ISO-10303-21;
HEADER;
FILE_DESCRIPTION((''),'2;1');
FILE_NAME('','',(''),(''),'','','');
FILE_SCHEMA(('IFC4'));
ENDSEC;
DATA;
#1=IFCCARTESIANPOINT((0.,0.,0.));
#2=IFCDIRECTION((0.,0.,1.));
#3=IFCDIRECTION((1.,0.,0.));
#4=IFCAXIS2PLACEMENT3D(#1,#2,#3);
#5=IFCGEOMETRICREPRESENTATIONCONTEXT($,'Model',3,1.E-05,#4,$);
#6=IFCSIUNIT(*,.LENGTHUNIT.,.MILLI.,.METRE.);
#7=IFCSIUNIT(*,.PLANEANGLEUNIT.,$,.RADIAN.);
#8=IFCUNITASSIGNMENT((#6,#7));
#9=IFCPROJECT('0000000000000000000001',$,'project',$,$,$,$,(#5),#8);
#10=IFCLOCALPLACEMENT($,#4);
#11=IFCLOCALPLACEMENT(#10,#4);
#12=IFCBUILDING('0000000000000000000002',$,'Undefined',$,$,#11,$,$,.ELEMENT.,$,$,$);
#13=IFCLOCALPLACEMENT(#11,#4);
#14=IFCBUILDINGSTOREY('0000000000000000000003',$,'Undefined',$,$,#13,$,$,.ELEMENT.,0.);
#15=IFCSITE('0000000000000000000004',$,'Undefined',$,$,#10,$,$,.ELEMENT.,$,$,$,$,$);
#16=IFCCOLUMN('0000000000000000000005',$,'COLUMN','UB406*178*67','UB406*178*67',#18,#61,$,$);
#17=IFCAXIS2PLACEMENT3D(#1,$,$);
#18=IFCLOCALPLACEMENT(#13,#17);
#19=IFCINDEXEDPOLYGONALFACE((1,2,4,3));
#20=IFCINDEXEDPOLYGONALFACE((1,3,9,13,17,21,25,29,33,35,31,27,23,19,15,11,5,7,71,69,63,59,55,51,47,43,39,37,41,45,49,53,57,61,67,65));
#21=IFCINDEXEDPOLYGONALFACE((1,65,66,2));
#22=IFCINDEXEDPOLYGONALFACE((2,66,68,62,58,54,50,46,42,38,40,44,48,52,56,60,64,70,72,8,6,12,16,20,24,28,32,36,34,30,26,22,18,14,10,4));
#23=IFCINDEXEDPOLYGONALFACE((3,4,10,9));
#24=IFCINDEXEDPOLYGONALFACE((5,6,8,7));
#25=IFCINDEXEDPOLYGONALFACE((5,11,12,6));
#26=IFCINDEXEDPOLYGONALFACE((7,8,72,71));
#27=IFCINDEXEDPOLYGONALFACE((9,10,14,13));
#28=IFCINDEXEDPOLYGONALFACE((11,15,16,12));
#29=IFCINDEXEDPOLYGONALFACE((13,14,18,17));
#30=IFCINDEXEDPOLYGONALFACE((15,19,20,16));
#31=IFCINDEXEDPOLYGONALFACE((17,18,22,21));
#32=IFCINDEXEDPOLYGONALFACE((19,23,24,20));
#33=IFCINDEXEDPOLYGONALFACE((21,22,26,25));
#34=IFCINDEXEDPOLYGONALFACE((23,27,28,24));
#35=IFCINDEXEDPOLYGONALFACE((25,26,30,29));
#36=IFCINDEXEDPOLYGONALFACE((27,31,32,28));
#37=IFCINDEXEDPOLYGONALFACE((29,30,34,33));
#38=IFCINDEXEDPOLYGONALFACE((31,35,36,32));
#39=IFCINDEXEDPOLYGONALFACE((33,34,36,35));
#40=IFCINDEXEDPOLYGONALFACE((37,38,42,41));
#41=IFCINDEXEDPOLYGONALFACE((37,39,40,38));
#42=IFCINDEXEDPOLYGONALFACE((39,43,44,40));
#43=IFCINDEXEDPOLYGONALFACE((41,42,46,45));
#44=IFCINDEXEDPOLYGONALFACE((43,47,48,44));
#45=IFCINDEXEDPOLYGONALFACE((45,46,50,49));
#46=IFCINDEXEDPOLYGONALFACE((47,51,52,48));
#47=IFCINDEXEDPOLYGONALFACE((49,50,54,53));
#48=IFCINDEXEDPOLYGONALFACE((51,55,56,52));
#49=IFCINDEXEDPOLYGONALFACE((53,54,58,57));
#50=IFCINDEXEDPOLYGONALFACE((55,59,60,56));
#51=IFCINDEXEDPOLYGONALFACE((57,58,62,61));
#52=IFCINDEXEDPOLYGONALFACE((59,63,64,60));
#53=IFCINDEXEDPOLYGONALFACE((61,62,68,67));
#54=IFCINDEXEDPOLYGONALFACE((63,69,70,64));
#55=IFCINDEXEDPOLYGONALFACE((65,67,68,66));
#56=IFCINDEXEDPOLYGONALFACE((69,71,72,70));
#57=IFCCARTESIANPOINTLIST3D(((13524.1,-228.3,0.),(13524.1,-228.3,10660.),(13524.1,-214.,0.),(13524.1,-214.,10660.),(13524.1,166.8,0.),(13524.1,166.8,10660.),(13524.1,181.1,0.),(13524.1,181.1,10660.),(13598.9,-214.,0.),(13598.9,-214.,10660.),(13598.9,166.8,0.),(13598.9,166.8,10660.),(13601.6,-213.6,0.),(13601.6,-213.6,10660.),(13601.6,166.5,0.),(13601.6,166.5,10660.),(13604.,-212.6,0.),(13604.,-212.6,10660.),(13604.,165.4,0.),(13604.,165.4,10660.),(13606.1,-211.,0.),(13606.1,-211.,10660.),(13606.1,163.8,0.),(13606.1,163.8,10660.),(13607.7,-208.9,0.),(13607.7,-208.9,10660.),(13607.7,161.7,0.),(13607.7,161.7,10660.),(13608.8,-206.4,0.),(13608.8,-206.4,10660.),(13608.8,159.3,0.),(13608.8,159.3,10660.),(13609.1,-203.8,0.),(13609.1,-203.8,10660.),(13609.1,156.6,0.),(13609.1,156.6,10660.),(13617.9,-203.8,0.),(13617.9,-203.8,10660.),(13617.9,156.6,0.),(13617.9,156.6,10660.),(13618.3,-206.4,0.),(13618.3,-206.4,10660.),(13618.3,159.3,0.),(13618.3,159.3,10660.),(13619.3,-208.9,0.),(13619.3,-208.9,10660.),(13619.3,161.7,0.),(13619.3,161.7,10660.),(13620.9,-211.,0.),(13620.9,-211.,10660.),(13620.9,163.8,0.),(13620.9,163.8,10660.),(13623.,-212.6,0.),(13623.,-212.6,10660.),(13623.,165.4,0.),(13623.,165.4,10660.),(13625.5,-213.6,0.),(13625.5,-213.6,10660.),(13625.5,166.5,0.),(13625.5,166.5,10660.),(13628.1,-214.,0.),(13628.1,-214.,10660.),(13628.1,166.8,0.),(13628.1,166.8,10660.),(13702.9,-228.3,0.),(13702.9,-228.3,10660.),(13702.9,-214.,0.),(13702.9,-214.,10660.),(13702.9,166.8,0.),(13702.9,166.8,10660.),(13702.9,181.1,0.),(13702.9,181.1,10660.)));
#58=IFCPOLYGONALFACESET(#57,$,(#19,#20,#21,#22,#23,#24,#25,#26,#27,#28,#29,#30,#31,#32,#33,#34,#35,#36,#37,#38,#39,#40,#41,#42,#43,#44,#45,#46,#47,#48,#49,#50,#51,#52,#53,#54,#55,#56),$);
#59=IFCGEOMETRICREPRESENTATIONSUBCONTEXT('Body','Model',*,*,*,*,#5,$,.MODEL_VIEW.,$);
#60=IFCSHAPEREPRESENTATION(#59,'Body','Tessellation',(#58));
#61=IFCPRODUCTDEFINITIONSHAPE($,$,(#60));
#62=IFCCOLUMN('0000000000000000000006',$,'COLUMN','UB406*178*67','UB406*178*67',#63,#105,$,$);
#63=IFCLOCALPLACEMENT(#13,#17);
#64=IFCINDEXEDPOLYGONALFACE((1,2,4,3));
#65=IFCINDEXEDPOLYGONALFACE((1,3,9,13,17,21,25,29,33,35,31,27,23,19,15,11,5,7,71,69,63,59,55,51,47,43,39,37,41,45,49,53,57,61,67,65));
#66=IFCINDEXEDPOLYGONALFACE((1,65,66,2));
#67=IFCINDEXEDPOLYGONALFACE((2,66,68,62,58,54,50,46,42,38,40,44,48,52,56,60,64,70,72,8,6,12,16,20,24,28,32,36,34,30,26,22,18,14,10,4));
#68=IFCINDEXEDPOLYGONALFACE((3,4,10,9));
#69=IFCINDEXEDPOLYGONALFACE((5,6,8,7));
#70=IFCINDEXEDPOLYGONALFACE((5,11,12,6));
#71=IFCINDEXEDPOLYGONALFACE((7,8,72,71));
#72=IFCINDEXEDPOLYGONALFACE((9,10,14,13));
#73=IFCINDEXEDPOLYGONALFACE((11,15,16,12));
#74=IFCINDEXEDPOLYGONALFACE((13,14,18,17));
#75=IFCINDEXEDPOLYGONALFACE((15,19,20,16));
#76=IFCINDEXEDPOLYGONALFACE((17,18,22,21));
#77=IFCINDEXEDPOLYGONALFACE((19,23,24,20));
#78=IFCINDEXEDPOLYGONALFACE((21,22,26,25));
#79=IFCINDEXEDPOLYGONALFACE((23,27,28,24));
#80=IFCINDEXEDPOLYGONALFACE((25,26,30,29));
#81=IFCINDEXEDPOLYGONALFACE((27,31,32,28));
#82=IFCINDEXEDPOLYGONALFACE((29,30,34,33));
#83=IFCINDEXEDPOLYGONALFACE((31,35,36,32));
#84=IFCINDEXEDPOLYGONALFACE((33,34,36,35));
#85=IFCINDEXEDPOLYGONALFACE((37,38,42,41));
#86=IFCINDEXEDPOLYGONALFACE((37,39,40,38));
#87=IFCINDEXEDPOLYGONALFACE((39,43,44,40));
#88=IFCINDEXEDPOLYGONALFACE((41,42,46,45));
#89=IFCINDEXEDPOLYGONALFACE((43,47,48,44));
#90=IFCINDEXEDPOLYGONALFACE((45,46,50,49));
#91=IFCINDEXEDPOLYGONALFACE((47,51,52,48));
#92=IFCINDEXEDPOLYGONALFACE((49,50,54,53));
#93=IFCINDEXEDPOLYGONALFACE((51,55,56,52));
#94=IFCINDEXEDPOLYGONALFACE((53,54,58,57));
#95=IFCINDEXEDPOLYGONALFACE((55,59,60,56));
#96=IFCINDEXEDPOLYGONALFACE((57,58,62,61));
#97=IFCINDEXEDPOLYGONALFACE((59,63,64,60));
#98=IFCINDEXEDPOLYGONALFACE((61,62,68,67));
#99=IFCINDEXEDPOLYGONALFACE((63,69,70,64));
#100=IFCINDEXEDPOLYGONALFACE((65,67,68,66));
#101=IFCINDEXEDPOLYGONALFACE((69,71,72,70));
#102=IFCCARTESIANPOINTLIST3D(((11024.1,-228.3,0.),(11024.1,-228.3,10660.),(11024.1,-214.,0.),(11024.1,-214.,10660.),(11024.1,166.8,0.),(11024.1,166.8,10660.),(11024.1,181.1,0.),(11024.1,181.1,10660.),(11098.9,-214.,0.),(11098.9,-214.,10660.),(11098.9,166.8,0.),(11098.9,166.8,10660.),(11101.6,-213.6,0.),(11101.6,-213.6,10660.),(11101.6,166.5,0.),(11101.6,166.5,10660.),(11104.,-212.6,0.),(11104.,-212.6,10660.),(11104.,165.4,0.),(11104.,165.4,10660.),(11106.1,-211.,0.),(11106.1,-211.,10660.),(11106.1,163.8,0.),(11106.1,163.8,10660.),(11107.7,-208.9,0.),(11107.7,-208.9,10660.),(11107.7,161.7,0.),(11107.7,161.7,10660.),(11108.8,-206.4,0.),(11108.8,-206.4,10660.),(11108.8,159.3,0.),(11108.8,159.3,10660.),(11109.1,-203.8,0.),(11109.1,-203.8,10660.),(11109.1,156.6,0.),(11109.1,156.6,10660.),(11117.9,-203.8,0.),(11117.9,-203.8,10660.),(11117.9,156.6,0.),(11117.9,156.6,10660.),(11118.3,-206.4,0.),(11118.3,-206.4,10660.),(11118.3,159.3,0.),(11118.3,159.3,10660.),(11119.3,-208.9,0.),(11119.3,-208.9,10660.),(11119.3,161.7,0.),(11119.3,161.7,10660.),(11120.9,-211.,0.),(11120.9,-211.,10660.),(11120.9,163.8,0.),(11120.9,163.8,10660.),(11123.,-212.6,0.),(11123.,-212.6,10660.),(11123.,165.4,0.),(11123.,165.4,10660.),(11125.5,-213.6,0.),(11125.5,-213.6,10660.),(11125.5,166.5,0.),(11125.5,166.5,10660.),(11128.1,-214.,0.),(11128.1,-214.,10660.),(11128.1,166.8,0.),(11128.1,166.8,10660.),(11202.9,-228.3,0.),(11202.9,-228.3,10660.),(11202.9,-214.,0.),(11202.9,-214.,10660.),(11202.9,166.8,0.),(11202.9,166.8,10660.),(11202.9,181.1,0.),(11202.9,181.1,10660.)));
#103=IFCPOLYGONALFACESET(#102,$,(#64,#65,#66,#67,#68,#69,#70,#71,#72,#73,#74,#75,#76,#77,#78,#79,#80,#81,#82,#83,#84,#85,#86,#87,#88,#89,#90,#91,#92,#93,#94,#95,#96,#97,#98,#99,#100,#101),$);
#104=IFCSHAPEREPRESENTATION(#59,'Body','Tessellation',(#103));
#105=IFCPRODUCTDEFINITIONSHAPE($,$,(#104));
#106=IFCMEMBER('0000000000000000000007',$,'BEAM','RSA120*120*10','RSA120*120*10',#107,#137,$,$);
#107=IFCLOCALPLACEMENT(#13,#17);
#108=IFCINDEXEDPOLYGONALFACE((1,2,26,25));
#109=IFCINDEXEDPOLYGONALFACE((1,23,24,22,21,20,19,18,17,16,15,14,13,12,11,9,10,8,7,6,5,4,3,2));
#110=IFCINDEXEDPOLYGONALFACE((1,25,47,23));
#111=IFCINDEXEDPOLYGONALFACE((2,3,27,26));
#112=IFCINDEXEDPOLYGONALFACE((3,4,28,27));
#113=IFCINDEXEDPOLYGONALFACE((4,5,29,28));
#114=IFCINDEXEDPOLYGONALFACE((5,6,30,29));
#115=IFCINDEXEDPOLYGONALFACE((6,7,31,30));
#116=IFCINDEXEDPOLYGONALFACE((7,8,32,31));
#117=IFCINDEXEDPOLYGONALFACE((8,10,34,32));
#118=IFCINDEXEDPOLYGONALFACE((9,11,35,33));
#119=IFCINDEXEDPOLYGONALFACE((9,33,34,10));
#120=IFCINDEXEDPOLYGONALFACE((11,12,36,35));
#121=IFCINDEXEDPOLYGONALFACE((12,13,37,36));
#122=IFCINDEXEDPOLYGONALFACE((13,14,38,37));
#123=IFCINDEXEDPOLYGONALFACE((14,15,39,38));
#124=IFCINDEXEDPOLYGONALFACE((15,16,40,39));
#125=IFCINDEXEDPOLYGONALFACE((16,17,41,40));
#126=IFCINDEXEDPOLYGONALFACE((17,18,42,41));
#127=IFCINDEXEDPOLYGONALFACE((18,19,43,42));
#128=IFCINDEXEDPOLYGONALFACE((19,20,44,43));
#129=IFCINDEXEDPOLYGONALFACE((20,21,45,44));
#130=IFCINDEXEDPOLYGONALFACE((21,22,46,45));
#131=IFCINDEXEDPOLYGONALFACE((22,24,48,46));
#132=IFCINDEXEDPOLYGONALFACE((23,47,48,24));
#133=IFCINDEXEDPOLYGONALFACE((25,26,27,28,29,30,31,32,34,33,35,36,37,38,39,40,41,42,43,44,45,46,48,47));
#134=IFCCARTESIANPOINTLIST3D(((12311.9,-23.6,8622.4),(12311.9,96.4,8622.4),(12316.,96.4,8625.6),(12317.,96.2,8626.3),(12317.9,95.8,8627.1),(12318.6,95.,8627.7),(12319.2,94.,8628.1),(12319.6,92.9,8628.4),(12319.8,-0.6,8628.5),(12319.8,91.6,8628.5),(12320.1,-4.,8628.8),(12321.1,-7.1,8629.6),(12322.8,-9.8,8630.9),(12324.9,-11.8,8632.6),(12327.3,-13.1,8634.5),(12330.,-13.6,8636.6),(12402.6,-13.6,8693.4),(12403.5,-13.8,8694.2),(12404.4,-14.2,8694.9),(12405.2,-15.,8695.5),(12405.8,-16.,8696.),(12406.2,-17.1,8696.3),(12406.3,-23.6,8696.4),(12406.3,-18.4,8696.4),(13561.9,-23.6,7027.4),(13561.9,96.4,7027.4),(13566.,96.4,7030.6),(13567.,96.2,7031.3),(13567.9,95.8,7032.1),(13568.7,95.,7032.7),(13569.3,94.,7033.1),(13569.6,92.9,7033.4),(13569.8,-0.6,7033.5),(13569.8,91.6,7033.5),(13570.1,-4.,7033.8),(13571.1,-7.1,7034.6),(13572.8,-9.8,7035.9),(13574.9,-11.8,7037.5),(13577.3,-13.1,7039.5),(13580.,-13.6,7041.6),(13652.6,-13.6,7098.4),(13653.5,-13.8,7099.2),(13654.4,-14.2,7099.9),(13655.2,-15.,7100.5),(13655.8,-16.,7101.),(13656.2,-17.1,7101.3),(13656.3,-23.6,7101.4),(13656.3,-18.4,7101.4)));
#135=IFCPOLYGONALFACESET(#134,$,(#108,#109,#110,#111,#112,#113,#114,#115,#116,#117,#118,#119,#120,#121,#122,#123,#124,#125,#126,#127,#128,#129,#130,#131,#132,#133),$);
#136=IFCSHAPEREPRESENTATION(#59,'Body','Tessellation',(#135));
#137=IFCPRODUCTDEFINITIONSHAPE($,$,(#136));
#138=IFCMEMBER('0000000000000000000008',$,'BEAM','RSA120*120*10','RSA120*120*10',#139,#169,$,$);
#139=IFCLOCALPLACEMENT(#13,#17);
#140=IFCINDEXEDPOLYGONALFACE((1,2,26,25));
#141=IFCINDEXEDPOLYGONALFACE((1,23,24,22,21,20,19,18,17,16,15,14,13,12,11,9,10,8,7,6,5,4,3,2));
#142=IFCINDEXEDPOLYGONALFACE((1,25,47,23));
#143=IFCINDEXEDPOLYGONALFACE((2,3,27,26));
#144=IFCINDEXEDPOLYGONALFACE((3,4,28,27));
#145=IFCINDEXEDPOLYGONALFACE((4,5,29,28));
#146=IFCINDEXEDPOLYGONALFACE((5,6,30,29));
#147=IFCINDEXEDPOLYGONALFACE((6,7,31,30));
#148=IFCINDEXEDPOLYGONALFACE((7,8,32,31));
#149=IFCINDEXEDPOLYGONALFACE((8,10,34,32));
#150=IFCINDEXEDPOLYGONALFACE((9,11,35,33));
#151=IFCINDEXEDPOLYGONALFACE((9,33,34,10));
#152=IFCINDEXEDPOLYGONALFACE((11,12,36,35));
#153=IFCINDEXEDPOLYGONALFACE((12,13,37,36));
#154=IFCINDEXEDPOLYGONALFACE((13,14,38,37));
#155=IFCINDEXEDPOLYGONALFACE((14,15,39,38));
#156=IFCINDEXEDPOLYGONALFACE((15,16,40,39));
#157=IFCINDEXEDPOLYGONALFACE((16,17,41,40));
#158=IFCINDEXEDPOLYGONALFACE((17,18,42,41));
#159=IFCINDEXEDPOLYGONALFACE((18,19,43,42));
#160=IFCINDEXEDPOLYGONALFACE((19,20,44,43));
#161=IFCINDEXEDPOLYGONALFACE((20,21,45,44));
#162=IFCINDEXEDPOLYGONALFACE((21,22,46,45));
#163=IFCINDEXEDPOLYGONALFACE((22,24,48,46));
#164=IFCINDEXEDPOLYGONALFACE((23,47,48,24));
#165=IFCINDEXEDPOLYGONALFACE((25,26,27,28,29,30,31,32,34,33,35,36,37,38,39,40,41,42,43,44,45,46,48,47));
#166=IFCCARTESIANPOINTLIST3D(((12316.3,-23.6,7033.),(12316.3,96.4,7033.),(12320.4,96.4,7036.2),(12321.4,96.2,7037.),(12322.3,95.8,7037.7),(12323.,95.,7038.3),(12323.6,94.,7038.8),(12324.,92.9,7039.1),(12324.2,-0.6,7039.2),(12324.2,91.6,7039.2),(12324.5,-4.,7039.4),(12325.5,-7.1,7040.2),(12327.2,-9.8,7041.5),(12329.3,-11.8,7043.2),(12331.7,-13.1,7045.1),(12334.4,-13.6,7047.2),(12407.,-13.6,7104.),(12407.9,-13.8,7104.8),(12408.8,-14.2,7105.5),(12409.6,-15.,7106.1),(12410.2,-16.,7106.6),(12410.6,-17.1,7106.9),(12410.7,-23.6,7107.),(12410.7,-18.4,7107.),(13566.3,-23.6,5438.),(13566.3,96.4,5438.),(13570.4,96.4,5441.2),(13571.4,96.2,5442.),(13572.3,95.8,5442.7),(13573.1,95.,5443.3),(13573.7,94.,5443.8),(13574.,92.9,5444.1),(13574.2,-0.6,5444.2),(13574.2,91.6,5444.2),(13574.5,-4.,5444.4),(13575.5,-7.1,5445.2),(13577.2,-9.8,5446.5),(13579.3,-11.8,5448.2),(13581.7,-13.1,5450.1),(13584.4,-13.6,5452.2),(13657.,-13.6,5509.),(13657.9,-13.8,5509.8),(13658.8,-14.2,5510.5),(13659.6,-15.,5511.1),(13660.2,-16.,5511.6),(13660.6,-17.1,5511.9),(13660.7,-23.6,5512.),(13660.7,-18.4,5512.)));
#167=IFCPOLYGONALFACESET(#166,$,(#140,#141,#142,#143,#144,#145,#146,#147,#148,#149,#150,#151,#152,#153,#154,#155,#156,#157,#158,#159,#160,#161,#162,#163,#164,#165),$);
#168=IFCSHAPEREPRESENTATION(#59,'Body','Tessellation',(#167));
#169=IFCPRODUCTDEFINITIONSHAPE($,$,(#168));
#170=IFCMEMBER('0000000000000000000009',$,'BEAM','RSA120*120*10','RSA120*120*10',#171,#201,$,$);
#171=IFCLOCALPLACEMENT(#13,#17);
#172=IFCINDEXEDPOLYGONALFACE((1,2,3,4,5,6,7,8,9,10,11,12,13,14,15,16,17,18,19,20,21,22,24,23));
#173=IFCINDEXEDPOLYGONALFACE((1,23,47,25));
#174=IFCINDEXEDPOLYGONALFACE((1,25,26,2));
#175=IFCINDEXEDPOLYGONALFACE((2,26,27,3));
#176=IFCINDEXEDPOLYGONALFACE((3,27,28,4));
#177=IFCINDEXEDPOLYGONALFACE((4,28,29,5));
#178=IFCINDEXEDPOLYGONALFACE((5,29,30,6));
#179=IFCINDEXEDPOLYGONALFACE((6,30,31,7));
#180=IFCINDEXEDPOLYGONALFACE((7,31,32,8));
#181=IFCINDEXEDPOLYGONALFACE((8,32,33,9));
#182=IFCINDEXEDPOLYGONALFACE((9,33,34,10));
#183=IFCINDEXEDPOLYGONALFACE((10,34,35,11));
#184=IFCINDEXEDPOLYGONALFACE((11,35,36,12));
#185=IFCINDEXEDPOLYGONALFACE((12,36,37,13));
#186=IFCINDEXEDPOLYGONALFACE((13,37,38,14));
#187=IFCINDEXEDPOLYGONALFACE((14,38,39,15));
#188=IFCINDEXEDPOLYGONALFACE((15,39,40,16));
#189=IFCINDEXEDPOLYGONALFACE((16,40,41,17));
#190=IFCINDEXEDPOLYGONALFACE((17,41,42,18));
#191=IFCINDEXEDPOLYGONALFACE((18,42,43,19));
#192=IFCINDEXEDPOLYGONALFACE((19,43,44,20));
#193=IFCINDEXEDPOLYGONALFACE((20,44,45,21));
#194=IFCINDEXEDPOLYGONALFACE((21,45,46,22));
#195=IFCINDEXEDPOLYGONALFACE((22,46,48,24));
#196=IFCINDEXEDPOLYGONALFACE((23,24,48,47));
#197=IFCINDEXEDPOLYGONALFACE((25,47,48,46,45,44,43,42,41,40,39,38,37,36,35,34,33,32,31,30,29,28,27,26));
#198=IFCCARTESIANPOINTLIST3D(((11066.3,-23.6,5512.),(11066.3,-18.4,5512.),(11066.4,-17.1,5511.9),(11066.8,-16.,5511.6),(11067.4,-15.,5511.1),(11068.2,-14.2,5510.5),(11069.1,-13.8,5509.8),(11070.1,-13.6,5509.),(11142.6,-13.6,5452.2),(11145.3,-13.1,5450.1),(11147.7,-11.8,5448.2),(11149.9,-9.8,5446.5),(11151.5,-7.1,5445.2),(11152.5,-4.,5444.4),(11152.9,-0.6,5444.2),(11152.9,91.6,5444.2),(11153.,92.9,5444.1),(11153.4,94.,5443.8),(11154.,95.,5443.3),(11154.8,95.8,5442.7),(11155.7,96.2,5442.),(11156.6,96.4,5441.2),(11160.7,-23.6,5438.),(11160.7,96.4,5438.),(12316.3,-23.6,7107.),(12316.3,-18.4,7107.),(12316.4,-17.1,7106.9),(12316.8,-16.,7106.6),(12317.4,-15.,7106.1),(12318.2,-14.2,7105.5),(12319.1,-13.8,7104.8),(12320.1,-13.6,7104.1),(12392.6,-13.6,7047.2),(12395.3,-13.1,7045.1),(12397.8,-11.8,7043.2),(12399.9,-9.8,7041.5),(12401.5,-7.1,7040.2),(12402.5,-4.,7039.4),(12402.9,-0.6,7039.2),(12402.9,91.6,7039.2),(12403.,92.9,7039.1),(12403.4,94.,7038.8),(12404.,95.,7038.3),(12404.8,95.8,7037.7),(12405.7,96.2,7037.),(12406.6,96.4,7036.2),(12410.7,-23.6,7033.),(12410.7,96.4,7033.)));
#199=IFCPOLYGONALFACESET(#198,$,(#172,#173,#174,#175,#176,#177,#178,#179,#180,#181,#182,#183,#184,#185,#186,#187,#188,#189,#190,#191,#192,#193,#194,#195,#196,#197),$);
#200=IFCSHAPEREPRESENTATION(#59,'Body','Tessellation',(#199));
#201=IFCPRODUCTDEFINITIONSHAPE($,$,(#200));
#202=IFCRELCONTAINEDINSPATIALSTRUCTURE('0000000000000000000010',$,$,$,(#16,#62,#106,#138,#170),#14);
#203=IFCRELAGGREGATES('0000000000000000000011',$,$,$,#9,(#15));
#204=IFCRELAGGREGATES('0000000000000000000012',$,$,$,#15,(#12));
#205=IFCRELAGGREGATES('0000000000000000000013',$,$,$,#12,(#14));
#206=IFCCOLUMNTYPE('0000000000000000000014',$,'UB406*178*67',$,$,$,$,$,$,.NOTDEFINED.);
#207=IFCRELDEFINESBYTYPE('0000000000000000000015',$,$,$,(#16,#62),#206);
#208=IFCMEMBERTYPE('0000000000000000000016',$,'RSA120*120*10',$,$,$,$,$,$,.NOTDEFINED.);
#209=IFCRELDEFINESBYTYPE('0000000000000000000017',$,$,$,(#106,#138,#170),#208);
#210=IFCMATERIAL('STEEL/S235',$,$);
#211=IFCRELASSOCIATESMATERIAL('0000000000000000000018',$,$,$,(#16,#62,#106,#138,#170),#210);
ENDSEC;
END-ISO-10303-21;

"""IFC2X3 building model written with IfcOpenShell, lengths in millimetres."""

from ifc_helpers import new_model, si_unit, frame, origin_with_axes, origin_2d_with_axis, place, context, subcontext, project, spatial, i_section, l_section, extrude, material, type_object, element, save


model = new_model("IFC2X3")

# Units and contexts
model_context = context("Model", 3, precision=1e-05, world=origin_with_axes())
body_context = subcontext(model_context, "Body", "Model", "MODEL_VIEW")
ifc_project = project(units=[si_unit("LENGTHUNIT", "METRE", prefix="MILLI"), si_unit("PLANEANGLEUNIT", "RADIAN")], contexts=[model_context])

# Site, building, storey
site_placement = place(None, origin_with_axes())
site = spatial("IfcSite", under=ifc_project, at=site_placement, Name="Undefined", CompositionType="ELEMENT")
building_placement = place(site_placement, origin_with_axes())
building = spatial("IfcBuilding", under=site, at=building_placement, Name="Undefined", CompositionType="ELEMENT")
storey_placement = place(building_placement, origin_with_axes())
storey = spatial("IfcBuildingStorey", under=building, at=storey_placement, Name="Undefined", CompositionType="ELEMENT", Elevation=0.0)

# Columns
ifc_material = material(Name="STEEL/S235")
column_type = type_object("IfcColumnType", Name="UB406*178*67", PredefinedType="NOTDEFINED")
for number, where, z_axis, x_axis, name in (
    (1, (13613.5, -23.6, 0.0), (0.0, 0.0, 1.0), (0.0, -1.0, 0.0), "COLUMN"),
    (2, (11113.5, -23.6, 0.0), (0.0, 0.0, 1.0), (0.0, -1.0, 0.0), "COLUMN"),
):
    element("IfcColumn", number, at=place(storey_placement, frame(where, z_axis=z_axis, x_axis=x_axis)), inside=storey, type_object=column_type, material=ifc_material, Name=name, Description="UB406*178*67", ObjectType="UB406*178*67", context=body_context, shape_type="SweptSolid", body=[
        extrude(i_section(OverallWidth=178.8, OverallDepth=409.4, WebThickness=8.8, FlangeThickness=14.3, FilletRadius=10.2, at=origin_2d_with_axis()), frame((0.0, 0.0, 10660.0), z_axis=(0.0, 0.0, -1.0), x_axis=(0.0, 1.0, 0.0)), (0.0, 0.0, 1.0), 10660.0),
    ])

# Members
member_type_1 = type_object("IfcMemberType", Name="RSA120*120*10", PredefinedType="NOTDEFINED")
for number, where, z_axis, x_axis, name in (
    (3, (13609.1, 36.4, 7064.4), (0.787088, 0.0, 0.61684), (-0.61684, 0.0, 0.787088), "BEAM"),
    (4, (13613.5, 36.4, 5475.0), (0.787088, 0.0, 0.61684), (-0.61684, 0.0, 0.787088), "BEAM"),
):
    element("IfcMember", number, at=place(storey_placement, frame(where, z_axis=z_axis, x_axis=x_axis)), inside=storey, type_object=member_type_1, material=ifc_material, Name=name, Description="RSA120*120*10", ObjectType="RSA120*120*10", context=body_context, shape_type="SweptSolid", body=[
        extrude(l_section(Depth=120.0, Width=120.0, Thickness=10.0, FilletRadius=13.0, EdgeRadius=4.8, at=origin_2d_with_axis()), frame((2026.5, 0.0, 0.0), z_axis=(-1.0, 0.0, 0.0), x_axis=(0.0, -1.0, 0.0)), (0.0, 0.0, 1.0), 2026.5),
    ])
member_placement = place(storey_placement, frame((12363.5, 36.4, 7070.0), z_axis=(-0.787088, 0.0, 0.616841), x_axis=(-0.616841, 0.0, -0.787088)))
element("IfcMember", 5, at=member_placement, inside=storey, type_object=member_type_1, material=ifc_material, Name="BEAM", Description="RSA120*120*10", ObjectType="RSA120*120*10", context=body_context, shape_type="SweptSolid", body=[
    extrude(l_section(Depth=120.0, Width=120.0, Thickness=10.0, FilletRadius=13.0, EdgeRadius=4.8, at=origin_2d_with_axis()), frame((2026.5, 0.0, 0.0), z_axis=(-1.0, 0.0, 0.0), x_axis=(0.0, -1.0, 0.0)), (0.0, 0.0, 1.0), 2026.5),
])

save(model, "model.ifc")
